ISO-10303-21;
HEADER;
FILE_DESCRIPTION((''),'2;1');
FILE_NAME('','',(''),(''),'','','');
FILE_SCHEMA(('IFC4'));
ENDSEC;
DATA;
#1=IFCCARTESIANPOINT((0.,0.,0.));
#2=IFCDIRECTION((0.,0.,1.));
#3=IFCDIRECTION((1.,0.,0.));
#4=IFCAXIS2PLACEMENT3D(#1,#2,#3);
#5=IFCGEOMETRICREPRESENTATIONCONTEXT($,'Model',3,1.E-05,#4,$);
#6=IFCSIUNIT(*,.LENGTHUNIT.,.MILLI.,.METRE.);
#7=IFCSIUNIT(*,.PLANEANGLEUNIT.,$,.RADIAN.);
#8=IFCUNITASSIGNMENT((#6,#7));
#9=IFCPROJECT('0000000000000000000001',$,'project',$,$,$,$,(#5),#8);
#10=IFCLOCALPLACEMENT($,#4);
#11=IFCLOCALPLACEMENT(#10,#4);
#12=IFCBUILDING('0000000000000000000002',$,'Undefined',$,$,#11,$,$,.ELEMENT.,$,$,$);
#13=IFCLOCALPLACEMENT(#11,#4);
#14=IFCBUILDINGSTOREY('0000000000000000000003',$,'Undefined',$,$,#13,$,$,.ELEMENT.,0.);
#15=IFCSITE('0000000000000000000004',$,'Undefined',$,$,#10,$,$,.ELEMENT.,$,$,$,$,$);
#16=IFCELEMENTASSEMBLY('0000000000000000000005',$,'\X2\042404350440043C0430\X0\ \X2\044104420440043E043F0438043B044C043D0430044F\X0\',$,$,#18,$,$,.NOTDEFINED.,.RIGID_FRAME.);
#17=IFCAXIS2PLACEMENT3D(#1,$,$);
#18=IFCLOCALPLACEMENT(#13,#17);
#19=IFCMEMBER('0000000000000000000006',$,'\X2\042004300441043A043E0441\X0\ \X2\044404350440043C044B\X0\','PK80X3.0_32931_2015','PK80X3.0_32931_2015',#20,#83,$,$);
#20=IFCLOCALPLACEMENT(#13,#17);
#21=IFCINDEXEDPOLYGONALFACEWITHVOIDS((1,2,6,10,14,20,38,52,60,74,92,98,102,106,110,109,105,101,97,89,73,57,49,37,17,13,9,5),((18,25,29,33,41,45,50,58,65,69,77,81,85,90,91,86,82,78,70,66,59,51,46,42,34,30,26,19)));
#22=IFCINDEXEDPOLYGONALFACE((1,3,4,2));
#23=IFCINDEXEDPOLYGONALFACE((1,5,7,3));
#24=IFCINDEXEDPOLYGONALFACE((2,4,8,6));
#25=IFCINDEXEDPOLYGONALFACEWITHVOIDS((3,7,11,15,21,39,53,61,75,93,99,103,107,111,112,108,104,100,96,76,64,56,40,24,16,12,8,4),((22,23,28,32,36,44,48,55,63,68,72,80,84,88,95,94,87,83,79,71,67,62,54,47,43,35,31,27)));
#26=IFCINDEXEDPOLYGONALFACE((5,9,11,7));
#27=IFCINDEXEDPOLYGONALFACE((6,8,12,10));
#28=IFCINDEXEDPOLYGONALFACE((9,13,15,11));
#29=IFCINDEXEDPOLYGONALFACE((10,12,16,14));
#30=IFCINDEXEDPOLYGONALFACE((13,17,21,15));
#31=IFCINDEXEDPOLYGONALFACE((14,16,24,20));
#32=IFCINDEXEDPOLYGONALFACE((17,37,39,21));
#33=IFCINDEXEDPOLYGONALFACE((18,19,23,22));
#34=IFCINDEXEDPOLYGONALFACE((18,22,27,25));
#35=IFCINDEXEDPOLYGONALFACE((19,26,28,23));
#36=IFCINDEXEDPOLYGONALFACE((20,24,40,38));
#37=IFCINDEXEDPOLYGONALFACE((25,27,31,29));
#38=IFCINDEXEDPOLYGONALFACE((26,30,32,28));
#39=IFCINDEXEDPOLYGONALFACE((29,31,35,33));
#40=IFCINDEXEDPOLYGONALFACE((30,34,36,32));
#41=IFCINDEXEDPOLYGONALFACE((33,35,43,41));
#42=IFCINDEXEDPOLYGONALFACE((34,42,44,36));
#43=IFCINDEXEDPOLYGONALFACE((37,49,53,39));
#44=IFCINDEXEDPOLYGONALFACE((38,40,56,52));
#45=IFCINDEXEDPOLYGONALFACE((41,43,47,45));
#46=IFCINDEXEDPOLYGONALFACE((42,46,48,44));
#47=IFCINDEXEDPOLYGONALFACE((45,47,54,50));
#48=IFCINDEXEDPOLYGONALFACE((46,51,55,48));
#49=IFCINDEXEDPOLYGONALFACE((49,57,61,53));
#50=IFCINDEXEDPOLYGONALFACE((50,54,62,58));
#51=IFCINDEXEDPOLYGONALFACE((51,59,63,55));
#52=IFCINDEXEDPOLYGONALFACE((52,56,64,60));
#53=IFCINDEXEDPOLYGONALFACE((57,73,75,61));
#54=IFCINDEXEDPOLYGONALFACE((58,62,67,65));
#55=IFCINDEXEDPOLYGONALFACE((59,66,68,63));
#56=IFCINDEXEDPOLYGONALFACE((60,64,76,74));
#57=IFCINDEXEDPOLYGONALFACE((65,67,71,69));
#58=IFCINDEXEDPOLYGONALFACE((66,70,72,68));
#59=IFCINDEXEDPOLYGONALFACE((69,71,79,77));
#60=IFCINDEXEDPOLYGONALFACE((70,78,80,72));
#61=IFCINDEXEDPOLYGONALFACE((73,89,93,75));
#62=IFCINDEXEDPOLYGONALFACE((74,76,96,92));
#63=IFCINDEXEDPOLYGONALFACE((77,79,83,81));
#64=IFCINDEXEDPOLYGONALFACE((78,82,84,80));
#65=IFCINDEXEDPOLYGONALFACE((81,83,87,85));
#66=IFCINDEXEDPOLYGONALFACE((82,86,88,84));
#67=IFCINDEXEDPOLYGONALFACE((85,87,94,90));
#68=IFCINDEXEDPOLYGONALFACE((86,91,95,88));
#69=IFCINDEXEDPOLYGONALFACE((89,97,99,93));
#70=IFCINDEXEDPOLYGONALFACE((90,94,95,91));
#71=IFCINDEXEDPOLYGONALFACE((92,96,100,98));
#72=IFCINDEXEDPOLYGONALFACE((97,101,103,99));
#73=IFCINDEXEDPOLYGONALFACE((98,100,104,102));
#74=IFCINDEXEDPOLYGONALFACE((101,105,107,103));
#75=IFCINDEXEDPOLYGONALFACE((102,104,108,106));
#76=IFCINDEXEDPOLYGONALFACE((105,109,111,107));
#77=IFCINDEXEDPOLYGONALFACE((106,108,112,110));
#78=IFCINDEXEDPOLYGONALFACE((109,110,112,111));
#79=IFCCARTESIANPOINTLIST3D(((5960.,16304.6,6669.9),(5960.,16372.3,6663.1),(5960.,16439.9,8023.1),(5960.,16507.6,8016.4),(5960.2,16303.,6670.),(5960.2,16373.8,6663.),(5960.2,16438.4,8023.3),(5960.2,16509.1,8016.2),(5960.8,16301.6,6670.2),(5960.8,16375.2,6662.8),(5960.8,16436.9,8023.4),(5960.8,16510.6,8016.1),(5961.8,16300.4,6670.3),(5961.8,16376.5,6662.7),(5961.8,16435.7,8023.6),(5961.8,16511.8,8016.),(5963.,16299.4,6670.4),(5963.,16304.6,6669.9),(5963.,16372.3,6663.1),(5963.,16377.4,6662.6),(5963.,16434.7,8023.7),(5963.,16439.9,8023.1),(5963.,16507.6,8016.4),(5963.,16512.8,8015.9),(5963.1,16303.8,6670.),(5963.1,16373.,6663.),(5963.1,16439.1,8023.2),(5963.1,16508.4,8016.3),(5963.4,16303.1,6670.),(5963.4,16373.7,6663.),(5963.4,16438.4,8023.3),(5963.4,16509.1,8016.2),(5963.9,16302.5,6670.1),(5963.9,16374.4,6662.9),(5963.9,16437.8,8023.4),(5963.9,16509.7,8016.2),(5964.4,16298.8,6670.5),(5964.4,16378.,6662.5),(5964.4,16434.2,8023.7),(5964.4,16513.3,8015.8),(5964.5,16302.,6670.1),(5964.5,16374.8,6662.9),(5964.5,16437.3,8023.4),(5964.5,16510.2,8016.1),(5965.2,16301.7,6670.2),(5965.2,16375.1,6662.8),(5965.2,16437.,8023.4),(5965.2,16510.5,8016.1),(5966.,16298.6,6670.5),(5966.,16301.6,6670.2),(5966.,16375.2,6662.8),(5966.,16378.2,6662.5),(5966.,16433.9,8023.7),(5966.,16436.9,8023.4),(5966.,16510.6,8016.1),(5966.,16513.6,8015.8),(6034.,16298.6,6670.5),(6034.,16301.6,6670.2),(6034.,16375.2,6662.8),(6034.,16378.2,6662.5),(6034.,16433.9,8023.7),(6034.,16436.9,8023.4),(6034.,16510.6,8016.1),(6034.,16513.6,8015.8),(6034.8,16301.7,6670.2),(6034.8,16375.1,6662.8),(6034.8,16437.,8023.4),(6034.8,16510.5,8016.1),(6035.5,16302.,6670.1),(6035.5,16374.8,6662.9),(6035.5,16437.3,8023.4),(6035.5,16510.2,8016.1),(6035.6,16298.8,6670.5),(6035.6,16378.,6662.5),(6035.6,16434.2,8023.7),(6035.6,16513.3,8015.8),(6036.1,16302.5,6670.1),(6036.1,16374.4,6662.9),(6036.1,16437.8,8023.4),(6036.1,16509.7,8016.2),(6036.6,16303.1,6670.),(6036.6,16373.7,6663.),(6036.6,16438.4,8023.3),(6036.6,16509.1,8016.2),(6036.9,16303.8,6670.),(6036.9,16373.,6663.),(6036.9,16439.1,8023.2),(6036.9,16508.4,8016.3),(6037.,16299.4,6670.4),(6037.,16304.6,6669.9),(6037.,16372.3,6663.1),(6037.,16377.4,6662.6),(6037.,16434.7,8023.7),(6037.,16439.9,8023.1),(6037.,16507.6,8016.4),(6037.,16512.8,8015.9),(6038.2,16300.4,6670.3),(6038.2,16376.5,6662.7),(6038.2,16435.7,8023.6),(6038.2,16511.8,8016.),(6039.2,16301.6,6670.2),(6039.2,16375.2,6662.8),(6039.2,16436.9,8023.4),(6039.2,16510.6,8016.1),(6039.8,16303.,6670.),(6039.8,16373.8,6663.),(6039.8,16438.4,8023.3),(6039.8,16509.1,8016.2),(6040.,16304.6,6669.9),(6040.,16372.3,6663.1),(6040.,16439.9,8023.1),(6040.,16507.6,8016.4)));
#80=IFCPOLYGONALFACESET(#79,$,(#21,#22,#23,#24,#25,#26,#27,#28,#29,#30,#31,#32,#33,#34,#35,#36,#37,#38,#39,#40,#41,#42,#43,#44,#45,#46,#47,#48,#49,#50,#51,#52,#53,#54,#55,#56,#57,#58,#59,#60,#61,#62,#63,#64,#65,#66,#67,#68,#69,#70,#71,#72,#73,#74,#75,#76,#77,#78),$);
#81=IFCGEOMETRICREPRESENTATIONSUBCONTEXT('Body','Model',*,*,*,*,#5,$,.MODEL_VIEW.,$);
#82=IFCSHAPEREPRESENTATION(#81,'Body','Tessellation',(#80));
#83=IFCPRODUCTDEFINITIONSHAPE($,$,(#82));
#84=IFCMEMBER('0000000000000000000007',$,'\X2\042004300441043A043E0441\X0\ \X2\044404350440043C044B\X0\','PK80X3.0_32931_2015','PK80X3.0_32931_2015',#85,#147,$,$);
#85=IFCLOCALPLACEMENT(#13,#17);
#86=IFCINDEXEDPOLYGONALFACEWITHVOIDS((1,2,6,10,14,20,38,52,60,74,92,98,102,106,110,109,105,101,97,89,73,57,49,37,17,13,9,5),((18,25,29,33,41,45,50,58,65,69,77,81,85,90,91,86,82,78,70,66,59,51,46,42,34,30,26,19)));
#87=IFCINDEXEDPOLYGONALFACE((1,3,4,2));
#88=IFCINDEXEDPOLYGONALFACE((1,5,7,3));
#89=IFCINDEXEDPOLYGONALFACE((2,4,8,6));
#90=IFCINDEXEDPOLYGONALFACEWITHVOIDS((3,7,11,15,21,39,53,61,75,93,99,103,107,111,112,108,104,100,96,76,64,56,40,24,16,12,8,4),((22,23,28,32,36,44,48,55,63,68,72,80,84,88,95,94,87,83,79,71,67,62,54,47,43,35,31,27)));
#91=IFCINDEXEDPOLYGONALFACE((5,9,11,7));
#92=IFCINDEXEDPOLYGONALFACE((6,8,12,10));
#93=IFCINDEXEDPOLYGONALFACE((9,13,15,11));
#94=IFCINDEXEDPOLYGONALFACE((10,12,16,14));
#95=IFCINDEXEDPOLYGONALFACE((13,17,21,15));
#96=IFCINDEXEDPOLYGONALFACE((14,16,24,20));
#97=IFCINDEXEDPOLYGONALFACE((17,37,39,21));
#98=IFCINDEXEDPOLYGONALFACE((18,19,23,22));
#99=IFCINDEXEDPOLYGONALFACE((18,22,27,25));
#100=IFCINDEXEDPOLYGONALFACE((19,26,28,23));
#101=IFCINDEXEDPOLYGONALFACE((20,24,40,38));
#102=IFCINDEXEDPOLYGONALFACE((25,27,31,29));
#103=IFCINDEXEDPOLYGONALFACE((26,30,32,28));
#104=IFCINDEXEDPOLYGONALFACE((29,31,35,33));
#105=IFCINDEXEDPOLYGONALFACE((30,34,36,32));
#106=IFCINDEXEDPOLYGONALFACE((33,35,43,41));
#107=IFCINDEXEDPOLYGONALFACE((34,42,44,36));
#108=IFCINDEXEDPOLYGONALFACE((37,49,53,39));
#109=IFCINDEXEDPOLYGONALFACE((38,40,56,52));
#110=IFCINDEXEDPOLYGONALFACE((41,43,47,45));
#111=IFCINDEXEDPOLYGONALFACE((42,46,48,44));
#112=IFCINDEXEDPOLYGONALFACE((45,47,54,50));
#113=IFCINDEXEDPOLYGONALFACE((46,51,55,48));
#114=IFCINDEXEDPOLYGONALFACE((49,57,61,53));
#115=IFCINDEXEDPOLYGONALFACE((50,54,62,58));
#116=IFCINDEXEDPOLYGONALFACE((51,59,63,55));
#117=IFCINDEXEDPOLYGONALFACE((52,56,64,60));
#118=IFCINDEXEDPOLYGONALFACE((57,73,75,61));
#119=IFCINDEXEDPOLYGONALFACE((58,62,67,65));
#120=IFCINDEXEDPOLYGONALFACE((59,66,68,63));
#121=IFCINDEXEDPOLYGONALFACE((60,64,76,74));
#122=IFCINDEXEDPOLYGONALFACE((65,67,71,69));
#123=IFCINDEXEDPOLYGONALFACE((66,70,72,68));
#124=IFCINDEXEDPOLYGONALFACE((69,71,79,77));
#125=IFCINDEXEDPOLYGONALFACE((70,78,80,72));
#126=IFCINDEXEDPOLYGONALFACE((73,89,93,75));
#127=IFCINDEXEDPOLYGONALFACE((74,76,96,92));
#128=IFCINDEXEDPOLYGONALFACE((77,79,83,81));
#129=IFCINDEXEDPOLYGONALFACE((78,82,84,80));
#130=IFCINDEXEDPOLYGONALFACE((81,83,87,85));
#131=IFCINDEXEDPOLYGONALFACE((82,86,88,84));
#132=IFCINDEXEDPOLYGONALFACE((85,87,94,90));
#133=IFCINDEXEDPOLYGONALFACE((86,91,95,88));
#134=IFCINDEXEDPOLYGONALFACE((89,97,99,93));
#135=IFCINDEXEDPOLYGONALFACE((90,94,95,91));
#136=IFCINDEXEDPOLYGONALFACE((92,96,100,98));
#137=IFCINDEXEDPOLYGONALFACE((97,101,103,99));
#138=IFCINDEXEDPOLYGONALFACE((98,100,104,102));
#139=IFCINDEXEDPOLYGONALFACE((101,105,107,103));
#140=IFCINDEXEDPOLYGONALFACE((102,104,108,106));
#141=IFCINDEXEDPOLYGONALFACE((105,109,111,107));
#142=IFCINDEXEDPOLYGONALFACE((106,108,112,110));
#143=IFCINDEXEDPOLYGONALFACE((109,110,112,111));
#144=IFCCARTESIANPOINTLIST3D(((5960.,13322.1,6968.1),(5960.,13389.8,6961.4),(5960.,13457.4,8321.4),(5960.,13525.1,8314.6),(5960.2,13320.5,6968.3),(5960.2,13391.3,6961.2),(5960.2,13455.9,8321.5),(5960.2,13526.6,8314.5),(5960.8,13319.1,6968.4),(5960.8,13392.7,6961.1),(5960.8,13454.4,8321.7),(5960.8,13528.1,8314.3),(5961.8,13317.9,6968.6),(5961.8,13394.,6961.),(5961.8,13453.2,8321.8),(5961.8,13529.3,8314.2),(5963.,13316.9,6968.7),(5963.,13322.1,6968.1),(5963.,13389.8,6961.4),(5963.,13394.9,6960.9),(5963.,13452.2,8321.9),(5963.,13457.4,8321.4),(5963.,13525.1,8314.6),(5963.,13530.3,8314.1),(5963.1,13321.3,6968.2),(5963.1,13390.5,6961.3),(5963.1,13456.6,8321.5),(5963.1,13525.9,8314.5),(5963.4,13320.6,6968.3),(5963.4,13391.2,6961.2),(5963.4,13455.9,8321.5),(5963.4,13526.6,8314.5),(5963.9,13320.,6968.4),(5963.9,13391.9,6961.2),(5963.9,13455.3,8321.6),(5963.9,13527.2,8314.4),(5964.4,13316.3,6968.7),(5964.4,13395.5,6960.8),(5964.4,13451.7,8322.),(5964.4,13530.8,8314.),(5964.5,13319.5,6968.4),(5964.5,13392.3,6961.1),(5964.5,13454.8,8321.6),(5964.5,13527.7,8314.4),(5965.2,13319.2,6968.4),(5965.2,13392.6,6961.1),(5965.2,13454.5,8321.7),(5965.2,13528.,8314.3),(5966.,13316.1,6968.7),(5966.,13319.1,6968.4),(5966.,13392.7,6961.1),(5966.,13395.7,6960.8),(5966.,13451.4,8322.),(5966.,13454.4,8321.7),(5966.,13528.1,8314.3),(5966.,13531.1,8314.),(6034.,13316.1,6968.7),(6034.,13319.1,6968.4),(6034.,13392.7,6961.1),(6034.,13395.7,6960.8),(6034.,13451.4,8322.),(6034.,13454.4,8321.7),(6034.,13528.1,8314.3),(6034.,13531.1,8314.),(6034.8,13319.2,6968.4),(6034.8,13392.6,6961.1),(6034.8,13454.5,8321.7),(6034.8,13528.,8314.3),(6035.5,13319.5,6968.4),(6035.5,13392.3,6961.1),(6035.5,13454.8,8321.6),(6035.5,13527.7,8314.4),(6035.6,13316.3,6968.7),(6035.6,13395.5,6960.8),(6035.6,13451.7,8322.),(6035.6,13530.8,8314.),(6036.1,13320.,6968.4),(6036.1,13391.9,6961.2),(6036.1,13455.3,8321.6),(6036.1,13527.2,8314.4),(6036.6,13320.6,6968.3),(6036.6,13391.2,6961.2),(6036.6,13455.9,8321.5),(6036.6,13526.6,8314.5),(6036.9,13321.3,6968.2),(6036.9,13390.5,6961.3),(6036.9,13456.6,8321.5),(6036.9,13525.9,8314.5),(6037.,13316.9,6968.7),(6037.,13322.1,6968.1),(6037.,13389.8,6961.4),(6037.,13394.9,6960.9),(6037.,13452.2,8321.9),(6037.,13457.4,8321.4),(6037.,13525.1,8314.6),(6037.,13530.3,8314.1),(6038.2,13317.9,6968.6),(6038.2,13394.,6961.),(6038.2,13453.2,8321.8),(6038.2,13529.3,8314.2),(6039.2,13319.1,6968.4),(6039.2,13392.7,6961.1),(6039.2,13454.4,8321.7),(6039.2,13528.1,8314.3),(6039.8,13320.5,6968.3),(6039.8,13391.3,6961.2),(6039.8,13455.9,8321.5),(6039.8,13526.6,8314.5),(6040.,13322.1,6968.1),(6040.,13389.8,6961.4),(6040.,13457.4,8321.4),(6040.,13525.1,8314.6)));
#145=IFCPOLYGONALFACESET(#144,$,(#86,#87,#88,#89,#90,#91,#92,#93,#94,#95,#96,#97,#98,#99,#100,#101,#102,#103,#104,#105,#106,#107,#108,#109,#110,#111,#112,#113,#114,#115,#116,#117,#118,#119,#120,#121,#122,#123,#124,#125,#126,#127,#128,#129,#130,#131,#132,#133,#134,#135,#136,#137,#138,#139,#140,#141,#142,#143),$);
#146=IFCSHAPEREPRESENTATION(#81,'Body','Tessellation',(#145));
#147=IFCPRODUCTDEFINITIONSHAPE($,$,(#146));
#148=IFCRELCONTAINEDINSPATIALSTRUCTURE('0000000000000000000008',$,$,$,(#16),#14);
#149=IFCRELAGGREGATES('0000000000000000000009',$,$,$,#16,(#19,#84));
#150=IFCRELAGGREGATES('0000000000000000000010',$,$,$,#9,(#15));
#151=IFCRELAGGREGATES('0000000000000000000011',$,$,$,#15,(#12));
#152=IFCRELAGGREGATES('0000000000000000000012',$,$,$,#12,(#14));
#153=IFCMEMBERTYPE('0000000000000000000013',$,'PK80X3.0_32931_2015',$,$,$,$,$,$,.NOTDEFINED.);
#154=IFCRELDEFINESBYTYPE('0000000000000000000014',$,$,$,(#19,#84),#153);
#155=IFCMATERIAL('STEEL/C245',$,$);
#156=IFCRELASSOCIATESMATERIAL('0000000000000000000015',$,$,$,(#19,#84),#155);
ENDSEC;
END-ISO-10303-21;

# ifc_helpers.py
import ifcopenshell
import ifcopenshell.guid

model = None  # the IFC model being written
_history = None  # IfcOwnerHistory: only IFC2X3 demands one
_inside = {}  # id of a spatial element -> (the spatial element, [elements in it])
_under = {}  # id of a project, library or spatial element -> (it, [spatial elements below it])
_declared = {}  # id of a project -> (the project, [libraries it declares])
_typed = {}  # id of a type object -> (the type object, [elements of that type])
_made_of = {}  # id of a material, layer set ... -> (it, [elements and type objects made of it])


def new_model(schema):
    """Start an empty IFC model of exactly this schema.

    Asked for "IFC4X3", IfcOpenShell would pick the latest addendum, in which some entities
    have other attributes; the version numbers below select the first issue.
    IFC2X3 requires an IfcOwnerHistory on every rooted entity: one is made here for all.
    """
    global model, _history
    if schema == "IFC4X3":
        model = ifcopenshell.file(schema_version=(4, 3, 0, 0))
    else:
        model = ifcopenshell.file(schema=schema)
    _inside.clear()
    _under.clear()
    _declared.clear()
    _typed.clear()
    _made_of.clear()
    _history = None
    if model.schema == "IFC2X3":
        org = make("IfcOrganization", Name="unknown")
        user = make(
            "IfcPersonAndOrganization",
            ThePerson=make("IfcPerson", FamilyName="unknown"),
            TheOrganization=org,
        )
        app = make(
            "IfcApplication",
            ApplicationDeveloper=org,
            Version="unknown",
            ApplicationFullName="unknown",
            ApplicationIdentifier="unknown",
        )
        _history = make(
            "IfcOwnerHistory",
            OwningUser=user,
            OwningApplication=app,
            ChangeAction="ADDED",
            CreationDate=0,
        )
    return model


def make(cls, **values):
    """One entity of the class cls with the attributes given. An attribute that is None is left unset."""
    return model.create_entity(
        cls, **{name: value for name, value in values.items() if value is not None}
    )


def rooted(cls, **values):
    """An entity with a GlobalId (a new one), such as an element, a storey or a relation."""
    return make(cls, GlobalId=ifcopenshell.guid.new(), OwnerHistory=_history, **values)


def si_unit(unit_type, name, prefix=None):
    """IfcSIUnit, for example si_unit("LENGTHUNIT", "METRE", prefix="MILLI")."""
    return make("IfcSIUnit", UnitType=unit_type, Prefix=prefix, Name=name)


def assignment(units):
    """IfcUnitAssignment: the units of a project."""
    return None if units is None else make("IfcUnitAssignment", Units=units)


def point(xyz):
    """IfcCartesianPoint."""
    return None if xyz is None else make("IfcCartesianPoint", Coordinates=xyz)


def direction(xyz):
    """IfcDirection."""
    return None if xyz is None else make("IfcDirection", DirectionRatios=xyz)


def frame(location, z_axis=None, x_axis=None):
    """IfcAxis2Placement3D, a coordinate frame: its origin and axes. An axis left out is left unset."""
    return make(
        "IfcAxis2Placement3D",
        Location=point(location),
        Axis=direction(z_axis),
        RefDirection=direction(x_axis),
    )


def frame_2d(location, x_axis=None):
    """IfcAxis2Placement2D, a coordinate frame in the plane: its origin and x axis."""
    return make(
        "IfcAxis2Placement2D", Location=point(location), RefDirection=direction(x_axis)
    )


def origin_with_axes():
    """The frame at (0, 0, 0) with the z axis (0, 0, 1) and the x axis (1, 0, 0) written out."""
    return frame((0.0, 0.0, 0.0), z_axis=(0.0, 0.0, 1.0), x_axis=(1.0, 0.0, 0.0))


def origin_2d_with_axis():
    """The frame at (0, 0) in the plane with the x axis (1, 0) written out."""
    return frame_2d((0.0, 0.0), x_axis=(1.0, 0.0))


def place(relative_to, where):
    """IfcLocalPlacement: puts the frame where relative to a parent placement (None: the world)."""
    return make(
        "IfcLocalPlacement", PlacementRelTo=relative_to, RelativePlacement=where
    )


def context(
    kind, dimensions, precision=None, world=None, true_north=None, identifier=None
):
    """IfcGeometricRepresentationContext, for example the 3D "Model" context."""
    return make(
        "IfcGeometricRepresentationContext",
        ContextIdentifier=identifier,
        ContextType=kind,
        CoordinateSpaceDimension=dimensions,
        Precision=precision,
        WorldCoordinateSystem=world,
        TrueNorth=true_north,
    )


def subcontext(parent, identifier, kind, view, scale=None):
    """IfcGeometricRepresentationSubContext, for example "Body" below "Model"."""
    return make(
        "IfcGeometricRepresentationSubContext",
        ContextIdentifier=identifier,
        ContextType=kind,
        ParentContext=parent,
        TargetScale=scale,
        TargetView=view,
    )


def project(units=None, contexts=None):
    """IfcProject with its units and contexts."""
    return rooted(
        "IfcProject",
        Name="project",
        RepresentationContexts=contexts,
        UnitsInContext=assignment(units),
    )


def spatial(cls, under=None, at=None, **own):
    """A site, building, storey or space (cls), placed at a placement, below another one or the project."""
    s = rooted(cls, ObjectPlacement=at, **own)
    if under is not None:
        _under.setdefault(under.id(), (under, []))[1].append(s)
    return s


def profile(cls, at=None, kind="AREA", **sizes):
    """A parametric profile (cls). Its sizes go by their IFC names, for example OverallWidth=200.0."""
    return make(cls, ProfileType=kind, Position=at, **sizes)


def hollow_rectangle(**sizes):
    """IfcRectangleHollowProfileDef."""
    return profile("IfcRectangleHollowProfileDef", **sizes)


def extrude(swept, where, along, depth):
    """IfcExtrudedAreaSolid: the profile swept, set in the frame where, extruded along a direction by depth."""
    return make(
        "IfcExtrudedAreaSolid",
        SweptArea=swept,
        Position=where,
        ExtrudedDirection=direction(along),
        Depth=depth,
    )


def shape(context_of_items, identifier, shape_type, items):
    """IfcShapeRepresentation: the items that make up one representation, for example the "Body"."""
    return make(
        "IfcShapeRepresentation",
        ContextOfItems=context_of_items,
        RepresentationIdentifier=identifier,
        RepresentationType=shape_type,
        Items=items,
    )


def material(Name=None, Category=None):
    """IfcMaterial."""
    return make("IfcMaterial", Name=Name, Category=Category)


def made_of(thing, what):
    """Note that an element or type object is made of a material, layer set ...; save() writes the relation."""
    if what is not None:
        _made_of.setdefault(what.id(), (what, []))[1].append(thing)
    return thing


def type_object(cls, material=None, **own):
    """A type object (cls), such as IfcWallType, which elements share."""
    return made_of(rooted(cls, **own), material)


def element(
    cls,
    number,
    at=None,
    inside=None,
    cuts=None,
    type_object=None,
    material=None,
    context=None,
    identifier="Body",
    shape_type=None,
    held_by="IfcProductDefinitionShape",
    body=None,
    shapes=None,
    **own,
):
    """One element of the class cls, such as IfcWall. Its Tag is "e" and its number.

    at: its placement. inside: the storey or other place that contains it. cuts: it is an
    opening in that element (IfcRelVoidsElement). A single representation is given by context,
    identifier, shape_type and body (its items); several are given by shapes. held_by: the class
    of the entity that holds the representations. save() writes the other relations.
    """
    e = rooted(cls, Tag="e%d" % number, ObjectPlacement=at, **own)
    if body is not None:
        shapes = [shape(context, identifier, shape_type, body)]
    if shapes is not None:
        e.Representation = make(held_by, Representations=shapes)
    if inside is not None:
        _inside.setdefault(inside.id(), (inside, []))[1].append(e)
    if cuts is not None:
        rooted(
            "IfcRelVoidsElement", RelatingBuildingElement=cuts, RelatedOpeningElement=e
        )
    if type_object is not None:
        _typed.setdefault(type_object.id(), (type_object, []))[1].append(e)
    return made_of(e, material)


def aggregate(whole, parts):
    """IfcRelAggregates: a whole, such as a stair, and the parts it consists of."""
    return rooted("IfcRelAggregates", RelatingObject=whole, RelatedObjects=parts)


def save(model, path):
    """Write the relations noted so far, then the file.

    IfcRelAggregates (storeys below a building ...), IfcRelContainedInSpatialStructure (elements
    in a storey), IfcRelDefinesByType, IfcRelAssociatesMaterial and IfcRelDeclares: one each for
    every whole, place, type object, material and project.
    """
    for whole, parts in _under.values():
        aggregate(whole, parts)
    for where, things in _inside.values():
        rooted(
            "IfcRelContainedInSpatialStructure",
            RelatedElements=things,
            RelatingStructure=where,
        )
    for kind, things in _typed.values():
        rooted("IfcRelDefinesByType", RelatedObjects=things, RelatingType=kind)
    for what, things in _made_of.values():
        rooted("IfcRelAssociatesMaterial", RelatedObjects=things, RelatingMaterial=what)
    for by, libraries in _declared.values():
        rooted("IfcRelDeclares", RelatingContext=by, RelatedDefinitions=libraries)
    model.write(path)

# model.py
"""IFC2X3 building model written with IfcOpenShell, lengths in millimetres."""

from ifc_helpers import new_model, si_unit, frame, origin_with_axes, origin_2d_with_axis, place, context, subcontext, project, spatial, hollow_rectangle, extrude, material, type_object, element, aggregate, save


model = new_model("IFC2X3")

# Units and contexts
model_context = context("Model", 3, precision=1e-05, world=origin_with_axes())
body_context = subcontext(model_context, "Body", "Model", "MODEL_VIEW")
ifc_project = project(units=[si_unit("LENGTHUNIT", "METRE", prefix="MILLI"), si_unit("PLANEANGLEUNIT", "RADIAN")], contexts=[model_context])

# Site, building, storey
site_placement = place(None, origin_with_axes())
site = spatial("IfcSite", under=ifc_project, at=site_placement, Name="Undefined", CompositionType="ELEMENT")
building_placement = place(site_placement, origin_with_axes())
building = spatial("IfcBuilding", under=site, at=building_placement, Name="Undefined", CompositionType="ELEMENT")
storey_placement = place(building_placement, origin_with_axes())
storey = spatial("IfcBuildingStorey", under=building, at=storey_placement, Name="Undefined", CompositionType="ELEMENT", Elevation=0.0)

# Shared definitions
ifc_material_1 = material(Name="STEEL/C245")

# Element assembly, members
assembly_1_placement = place(storey_placement, origin_with_axes())
assembly_1 = element("IfcElementAssembly", 1, at=assembly_1_placement, inside=storey, Name="Ферма стропильная", AssemblyPlace="NOTDEFINED", PredefinedType="RIGID_FRAME")
member_type_1 = type_object("IfcMemberType", Name="PK80X3.0_32931_2015", PredefinedType="NOTDEFINED")
member_1_placement = place(assembly_1_placement, frame((6000.0, 16473.7, 8019.8), z_axis=(0.0, -0.995037, 0.099504), x_axis=(0.0, -0.099504, -0.995037)))
member_1 = element("IfcMember", 2, at=member_1_placement, type_object=member_type_1, material=ifc_material_1, Name="Раскос фермы", Description="PK80X3.0_32931_2015", ObjectType="PK80X3.0_32931_2015", context=body_context, shape_type="SweptSolid", body=[
    extrude(hollow_rectangle(XDim=80.0, YDim=80.0, WallThickness=3.0, InnerFilletRadius=3.0, OuterFilletRadius=6.0, at=origin_2d_with_axis()), frame((1360.0, 0.0, 0.0), z_axis=(-1.0, 0.0, 0.0), x_axis=(0.0, -1.0, 0.0)), (0.0, 0.0, 1.0), 1360.0),
])
member_2_placement = place(assembly_1_placement, frame((6000.0, 13491.2, 8318.0), z_axis=(0.0, -0.995037, 0.099504), x_axis=(0.0, -0.099504, -0.995037)))
member_2 = element("IfcMember", 3, at=member_2_placement, type_object=member_type_1, material=ifc_material_1, Name="Раскос фермы", Description="PK80X3.0_32931_2015", ObjectType="PK80X3.0_32931_2015", context=body_context, shape_type="SweptSolid", body=[
    extrude(hollow_rectangle(XDim=80.0, YDim=80.0, WallThickness=3.0, InnerFilletRadius=3.0, OuterFilletRadius=6.0, at=origin_2d_with_axis()), frame((1360.0, 0.0, 0.0), z_axis=(-1.0, 0.0, 0.0), x_axis=(0.0, -1.0, 0.0)), (0.0, 0.0, 1.0), 1360.0),
])
aggregate(assembly_1, [member_1, member_2])

save(model, "model.ifc")
